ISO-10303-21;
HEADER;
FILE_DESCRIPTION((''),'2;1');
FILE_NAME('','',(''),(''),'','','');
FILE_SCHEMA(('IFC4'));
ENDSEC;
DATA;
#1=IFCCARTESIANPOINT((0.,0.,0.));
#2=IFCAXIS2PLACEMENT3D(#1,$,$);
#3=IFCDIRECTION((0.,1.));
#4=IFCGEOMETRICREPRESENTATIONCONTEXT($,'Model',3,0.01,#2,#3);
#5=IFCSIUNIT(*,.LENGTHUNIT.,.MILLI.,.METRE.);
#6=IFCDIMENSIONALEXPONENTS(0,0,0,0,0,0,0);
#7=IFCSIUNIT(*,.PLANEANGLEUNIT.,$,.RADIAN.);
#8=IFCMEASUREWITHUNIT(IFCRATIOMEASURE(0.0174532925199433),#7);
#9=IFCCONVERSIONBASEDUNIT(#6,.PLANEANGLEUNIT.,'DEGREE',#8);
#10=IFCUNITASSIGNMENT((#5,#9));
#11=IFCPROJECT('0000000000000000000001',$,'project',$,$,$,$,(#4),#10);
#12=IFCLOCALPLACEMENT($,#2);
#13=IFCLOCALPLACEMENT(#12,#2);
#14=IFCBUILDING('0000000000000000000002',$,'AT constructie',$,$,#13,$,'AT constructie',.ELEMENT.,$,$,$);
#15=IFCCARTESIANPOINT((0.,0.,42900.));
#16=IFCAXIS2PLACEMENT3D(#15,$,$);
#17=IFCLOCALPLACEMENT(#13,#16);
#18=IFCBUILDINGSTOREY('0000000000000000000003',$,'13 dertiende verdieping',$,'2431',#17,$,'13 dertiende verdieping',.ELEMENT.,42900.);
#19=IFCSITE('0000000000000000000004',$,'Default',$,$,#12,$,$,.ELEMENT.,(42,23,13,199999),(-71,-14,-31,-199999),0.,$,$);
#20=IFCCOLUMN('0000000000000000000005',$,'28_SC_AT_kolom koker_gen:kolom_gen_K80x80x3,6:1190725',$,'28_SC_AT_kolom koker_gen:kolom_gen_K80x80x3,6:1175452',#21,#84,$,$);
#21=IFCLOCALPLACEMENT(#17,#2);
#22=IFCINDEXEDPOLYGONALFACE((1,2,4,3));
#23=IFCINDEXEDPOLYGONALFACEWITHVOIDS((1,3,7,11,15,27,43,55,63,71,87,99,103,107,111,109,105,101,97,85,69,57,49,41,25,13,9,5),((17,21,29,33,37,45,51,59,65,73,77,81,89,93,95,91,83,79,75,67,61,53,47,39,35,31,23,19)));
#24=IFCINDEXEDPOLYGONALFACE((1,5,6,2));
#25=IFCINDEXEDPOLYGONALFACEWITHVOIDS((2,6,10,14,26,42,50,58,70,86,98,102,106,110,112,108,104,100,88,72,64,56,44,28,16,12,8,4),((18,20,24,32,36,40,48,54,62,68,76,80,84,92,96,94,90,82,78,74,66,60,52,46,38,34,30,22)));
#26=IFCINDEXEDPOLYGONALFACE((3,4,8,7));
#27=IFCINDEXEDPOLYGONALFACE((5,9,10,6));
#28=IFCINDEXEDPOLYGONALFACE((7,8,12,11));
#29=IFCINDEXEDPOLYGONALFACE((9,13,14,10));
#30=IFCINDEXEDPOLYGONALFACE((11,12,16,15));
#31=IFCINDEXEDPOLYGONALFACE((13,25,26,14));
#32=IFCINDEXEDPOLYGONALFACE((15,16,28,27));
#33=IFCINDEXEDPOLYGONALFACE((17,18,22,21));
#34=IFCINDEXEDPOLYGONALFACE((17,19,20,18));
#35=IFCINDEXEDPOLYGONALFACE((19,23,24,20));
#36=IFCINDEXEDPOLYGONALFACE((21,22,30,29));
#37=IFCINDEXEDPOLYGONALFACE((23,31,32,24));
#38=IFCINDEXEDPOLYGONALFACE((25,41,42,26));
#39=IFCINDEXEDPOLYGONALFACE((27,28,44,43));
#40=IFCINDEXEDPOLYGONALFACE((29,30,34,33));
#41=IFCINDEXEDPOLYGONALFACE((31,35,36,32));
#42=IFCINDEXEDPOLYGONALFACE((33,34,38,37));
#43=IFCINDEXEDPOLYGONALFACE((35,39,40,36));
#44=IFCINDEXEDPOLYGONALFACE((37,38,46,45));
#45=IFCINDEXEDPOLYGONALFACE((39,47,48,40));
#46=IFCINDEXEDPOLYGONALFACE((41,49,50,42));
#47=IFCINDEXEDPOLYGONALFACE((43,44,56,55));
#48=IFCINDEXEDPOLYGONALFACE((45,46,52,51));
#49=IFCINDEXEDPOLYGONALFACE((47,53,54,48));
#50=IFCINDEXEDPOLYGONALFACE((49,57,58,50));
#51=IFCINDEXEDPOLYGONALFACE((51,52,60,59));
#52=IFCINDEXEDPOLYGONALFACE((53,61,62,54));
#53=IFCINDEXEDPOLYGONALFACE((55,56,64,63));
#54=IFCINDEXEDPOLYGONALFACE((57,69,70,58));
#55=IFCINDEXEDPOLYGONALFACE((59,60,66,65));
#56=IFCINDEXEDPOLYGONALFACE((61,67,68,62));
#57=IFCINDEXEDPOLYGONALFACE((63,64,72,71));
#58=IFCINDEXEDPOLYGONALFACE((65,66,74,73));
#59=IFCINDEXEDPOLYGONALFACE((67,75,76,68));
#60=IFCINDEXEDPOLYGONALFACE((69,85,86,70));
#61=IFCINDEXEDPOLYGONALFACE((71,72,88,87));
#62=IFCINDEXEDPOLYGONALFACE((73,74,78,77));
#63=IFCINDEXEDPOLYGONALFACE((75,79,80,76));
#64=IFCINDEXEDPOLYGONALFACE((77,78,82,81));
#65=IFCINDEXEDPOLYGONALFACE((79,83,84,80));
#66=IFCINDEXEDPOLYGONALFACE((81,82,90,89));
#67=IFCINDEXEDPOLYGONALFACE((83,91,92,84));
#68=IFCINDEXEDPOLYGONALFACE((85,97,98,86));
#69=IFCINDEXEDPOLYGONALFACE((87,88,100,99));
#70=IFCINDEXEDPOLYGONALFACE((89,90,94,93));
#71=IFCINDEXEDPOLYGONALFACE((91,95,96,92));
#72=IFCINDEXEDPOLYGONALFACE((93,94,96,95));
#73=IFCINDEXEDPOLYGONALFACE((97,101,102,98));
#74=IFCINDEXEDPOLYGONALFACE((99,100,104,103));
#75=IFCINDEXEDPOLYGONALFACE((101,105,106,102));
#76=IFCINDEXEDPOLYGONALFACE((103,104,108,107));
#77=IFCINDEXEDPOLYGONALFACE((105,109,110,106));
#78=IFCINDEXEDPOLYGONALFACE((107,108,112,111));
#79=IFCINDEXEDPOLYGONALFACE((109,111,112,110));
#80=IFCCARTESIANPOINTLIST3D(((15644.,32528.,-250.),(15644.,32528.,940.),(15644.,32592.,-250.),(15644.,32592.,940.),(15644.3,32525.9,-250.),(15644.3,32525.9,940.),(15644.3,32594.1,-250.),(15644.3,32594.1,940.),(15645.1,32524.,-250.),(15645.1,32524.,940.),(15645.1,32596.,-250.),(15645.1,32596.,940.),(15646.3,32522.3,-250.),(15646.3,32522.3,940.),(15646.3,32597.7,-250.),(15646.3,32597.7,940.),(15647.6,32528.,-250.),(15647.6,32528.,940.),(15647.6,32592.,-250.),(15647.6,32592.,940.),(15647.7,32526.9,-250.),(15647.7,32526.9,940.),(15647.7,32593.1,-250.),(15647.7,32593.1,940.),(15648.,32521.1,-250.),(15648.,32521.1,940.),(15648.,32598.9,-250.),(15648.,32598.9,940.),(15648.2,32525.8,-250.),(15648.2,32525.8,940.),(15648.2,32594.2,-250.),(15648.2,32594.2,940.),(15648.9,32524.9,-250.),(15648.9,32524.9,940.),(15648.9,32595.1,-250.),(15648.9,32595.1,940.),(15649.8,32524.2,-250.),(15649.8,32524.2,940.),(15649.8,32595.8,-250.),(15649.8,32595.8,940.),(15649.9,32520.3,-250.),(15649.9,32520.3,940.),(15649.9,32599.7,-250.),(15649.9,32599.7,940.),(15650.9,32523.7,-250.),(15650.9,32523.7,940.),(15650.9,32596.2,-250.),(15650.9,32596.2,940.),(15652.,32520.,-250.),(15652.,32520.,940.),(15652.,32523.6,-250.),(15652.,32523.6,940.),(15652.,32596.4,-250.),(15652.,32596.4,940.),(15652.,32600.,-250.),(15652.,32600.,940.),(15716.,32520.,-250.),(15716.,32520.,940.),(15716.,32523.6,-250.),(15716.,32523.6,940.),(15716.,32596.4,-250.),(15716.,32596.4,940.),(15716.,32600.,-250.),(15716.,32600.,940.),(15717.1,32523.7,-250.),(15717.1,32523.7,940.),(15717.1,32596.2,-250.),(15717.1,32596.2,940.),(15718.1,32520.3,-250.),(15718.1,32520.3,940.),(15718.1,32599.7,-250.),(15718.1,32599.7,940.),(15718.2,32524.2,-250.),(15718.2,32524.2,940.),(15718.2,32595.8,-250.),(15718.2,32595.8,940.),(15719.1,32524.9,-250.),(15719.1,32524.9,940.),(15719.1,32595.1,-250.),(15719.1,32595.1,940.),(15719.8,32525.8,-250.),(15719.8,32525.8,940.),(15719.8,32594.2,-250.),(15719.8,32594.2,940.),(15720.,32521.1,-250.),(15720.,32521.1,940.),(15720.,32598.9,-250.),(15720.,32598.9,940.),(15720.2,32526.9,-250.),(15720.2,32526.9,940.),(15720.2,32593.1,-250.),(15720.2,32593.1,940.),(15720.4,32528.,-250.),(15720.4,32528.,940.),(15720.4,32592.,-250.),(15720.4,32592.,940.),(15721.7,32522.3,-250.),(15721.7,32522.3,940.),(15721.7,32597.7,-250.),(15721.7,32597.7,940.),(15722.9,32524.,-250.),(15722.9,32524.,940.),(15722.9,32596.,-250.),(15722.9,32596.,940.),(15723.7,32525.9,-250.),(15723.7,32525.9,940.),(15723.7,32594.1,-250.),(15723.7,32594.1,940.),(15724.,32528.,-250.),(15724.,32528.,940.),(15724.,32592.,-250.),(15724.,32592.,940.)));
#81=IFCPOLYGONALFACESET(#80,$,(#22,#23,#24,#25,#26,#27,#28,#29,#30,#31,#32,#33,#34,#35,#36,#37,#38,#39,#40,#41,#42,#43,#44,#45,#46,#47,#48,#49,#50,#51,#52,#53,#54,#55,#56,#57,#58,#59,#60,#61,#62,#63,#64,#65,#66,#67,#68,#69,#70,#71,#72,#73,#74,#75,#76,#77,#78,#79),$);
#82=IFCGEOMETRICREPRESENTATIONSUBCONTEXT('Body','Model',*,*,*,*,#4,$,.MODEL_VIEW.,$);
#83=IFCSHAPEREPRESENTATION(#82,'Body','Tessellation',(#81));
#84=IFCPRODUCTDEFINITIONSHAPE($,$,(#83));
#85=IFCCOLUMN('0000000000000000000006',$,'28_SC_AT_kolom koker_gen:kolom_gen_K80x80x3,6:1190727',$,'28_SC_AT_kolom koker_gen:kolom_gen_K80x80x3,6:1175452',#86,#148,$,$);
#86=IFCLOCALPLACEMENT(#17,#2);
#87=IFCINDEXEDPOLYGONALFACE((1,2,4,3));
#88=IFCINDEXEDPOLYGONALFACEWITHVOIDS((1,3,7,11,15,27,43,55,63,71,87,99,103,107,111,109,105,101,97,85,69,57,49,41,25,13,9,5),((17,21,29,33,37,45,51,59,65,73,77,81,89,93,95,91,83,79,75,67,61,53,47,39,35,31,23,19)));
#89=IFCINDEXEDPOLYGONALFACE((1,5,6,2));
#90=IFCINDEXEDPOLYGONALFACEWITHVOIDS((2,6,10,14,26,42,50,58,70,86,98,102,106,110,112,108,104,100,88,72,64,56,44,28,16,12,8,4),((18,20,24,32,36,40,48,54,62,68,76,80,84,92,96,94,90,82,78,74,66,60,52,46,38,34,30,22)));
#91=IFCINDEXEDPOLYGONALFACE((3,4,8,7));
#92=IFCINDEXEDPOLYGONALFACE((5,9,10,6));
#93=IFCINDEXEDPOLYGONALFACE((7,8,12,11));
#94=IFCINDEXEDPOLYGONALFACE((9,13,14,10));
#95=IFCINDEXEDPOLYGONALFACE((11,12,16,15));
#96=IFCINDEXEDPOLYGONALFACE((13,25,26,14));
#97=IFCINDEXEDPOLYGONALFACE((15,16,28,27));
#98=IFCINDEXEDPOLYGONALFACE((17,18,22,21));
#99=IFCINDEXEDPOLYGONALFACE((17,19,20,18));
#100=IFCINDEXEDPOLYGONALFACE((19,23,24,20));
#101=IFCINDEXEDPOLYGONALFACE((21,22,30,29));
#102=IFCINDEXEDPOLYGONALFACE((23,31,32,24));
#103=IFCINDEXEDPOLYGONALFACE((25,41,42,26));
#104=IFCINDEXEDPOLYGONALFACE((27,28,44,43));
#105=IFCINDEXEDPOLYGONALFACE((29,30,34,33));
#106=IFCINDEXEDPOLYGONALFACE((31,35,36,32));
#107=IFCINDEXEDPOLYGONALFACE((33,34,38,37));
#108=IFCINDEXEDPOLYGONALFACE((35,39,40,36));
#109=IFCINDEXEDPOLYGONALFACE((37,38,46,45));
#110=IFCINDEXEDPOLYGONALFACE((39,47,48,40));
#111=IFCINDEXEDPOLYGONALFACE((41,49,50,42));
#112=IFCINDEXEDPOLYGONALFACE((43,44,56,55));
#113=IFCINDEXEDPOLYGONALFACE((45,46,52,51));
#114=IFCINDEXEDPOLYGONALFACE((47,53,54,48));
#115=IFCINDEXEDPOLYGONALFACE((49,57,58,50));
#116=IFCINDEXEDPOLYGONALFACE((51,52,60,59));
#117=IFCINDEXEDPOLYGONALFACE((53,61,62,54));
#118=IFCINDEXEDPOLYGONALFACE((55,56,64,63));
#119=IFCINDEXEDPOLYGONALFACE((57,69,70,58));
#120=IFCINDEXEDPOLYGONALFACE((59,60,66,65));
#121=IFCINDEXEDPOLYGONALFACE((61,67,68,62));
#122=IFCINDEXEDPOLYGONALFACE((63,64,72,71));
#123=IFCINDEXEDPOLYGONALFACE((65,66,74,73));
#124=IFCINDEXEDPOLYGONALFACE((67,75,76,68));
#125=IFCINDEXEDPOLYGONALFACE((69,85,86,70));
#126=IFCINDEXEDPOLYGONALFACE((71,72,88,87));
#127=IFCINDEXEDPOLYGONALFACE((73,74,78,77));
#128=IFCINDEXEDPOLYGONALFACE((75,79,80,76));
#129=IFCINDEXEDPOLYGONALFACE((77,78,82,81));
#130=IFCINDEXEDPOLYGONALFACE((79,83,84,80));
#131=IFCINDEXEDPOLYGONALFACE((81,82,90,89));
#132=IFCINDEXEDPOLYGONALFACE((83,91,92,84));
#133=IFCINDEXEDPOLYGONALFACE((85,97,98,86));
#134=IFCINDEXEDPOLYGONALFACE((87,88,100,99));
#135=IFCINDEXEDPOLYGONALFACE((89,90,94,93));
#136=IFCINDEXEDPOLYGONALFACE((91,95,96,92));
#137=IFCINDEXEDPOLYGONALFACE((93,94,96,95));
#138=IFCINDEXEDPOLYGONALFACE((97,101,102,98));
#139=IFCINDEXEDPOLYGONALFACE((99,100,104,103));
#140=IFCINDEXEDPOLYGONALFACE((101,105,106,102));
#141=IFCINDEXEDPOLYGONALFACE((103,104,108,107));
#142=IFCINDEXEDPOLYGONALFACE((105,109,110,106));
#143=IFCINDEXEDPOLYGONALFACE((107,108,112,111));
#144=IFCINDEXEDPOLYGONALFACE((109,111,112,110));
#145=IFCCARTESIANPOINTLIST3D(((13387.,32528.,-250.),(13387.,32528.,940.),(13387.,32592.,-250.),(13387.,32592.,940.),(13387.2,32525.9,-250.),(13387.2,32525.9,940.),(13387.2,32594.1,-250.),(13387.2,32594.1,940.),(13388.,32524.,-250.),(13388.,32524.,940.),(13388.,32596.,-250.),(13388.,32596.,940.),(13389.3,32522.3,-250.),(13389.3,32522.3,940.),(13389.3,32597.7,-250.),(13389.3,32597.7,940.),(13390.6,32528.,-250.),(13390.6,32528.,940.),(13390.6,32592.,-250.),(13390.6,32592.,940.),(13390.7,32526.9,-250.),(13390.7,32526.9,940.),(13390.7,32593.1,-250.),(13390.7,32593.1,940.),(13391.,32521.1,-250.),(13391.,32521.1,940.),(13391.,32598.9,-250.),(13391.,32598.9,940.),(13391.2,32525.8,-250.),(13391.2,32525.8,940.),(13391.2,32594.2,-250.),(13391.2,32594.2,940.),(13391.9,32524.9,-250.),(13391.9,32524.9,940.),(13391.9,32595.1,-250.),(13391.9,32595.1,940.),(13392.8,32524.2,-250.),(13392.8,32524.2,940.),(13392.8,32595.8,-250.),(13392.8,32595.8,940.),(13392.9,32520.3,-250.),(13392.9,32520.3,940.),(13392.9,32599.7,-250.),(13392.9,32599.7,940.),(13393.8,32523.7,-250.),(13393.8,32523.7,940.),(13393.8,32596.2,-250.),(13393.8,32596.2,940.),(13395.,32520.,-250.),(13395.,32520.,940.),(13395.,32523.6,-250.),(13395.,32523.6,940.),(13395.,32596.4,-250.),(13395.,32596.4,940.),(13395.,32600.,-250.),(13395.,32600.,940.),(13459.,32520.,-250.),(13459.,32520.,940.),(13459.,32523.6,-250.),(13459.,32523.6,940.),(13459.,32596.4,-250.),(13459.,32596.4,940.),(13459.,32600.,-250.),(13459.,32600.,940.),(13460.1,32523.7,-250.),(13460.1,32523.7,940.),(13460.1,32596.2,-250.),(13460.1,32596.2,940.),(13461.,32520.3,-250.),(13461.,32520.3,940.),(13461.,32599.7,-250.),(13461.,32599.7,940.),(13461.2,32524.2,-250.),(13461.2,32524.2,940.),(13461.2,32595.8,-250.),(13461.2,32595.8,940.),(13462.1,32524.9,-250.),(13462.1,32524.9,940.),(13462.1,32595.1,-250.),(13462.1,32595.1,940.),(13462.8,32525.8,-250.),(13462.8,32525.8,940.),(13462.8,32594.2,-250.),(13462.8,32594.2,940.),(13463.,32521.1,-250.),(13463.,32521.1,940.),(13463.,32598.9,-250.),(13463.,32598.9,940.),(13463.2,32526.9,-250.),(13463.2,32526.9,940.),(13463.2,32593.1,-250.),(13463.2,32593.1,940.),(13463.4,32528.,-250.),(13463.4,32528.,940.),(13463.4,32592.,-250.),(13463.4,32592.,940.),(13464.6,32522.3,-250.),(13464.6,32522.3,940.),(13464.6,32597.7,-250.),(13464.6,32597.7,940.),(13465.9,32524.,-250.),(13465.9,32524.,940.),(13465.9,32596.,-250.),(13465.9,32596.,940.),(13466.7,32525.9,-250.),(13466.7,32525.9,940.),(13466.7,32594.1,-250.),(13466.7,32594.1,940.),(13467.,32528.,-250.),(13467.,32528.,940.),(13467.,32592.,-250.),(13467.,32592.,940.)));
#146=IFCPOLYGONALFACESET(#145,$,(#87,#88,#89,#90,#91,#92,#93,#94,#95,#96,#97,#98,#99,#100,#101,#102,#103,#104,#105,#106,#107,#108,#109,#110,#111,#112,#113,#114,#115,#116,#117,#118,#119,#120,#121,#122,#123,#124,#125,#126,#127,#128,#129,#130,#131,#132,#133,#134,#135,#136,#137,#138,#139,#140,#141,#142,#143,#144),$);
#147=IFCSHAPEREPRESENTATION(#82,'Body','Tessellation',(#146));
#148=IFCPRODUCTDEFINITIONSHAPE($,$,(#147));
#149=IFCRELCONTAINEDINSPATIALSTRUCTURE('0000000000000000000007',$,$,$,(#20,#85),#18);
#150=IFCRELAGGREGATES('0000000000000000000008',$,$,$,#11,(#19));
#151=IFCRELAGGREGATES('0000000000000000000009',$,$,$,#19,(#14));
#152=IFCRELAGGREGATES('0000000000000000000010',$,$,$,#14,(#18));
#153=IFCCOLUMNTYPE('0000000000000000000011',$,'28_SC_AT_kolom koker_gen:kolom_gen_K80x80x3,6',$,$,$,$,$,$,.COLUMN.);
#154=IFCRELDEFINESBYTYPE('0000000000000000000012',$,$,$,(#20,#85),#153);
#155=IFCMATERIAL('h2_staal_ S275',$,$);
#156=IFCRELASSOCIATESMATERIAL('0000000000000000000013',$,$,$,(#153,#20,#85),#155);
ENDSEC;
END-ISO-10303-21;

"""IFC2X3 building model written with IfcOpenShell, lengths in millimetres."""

from ifc_helpers import new_model, entity, si_unit, converted_unit, direction, frame, frame_2d, origin, place, context, subcontext, project, spatial, polyline, circle_curve, parameter, trimmed, segment, composite_curve, outline, extrude, source, transform, mapped, material, type_object, type_shapes, element, save


model = new_model("IFC2X3")

# Units and contexts
model_context = context("Model", 3, precision=0.01, world=origin(), true_north=direction((0.0, 1.0)))
body_context = subcontext(model_context, "Body", "Model", "MODEL_VIEW")
ifc_project = project(units=[si_unit("LENGTHUNIT", "METRE", prefix="MILLI"), converted_unit("PLANEANGLEUNIT", "DEGREE", entity("IfcRatioMeasure", 0.0174532925199433), si_unit("PLANEANGLEUNIT", "RADIAN"), dimensions=[0, 0, 0, 0, 0, 0, 0])], contexts=[model_context])

# Site, building, storey
site_placement = place(None, origin())
site = spatial("IfcSite", under=ifc_project, at=site_placement, Name="Default", CompositionType="ELEMENT", RefLatitude=(42, 23, 13, 199999), RefLongitude=(-71, -14, -31, -199999), RefElevation=0.0)
building_placement = place(site_placement, origin())
building = spatial("IfcBuilding", under=site, at=building_placement, Name="AT constructie", LongName="AT constructie", CompositionType="ELEMENT")
storey_placement = place(building_placement, frame((0.0, 0.0, 42900.0)))
storey = spatial("IfcBuildingStorey", under=building, at=storey_placement, Name="13 dertiende verdieping", ObjectType="2431", LongName="13 dertiende verdieping", CompositionType="ELEMENT", Elevation=42900.0)

# Columns
ifc_material = material(Name="h2_staal_ S275")
column_type_1 = type_object("IfcColumnType", Name="28_SC_AT_kolom koker_gen:kolom_gen_K80x80x3,6", PredefinedType="COLUMN", material=ifc_material)
shared_shape_1 = source(origin(), body_context, "Body", "SweptSolid", [
    extrude(outline(composite_curve([segment(trimmed(circle_curve(frame_2d((32.0, 32.0), x_axis=(1.0, 0.0)), 8.0), [parameter(360.0)], [parameter(90.0)], True, "PARAMETER"), True, "CONTINUOUS"), segment(polyline([(32.0, 40.0), (-32.0, 40.0)]), True, "CONTINUOUS"), segment(trimmed(circle_curve(frame_2d((-32.0, 32.0), x_axis=(1.0, 0.0)), 8.0), [parameter(90.0)], [parameter(180.0)], True, "PARAMETER"), True, "CONTINUOUS"), segment(polyline([(-40.0, 32.0), (-40.0, -32.0)]), True, "CONTINUOUS"), segment(trimmed(circle_curve(frame_2d((-32.0, -32.0), x_axis=(1.0, 0.0)), 8.0), [parameter(180.0)], [parameter(270.0)], True, "PARAMETER"), True, "CONTINUOUS"), segment(polyline([(-32.0, -40.0), (32.0, -40.0)]), True, "CONTINUOUS"), segment(trimmed(circle_curve(frame_2d((32.0, -32.0), x_axis=(1.0, 0.0)), 8.0), [parameter(270.0)], [parameter(0.0)], True, "PARAMETER"), True, "CONTINUOUS"), segment(polyline([(40.0, -32.0), (40.0, 32.0)]), True, "CONTINUOUS")], self_intersect=False), holes=[composite_curve([segment(polyline([(-32.0, 36.4), (32.0, 36.4)]), True, "CONTINUOUS"), segment(trimmed(circle_curve(frame_2d((32.0, 32.0), x_axis=(1.0, 0.0)), 4.4), [parameter(360.0)], [parameter(90.0)], True, "PARAMETER"), False, "CONTINUOUS"), segment(polyline([(36.4, 32.0), (36.4, -32.0)]), True, "CONTINUOUS"), segment(trimmed(circle_curve(frame_2d((32.0, -32.0), x_axis=(1.0, 0.0)), 4.4), [parameter(270.0)], [parameter(360.0)], True, "PARAMETER"), False, "CONTINUOUS"), segment(polyline([(32.0, -36.4), (-32.0, -36.4)]), True, "CONTINUOUS"), segment(trimmed(circle_curve(frame_2d((-32.0, -32.0), x_axis=(1.0, 0.0)), 4.4), [parameter(180.0)], [parameter(270.0)], True, "PARAMETER"), False, "CONTINUOUS"), segment(polyline([(-36.4, -32.0), (-36.4, 32.0)]), True, "CONTINUOUS"), segment(trimmed(circle_curve(frame_2d((-32.0, 32.0), x_axis=(1.0, 0.0)), 4.4), [parameter(90.0)], [parameter(180.0)], True, "PARAMETER"), False, "CONTINUOUS")], self_intersect=False)]), frame((0.0, 0.0, 42650.0), z_axis=(0.0, 0.0, 1.0), x_axis=(-1.0, 0.0, 0.0)), (0.0, 0.0, 1.0), 1190.0),
])
type_shapes(column_type_1, [shared_shape_1])
for number, where, name in (
    (1, (15684.0, 32560.0, -42900.0), "28_SC_AT_kolom koker_gen:kolom_gen_K80x80x3,6:1190725"),
    (2, (13427.0, 32560.0, -42900.0), "28_SC_AT_kolom koker_gen:kolom_gen_K80x80x3,6:1190727"),
):
    element("IfcColumn", number, at=place(storey_placement, frame(where)), inside=storey, type_object=column_type_1, material=ifc_material, Name=name, ObjectType="28_SC_AT_kolom koker_gen:kolom_gen_K80x80x3,6:1175452", context=body_context, shape_type="MappedRepresentation", body=[
        mapped(shared_shape_1, transform((0.0, 0.0, 0.0), scale=1.0)),
    ])

save(model, "model.ifc")
